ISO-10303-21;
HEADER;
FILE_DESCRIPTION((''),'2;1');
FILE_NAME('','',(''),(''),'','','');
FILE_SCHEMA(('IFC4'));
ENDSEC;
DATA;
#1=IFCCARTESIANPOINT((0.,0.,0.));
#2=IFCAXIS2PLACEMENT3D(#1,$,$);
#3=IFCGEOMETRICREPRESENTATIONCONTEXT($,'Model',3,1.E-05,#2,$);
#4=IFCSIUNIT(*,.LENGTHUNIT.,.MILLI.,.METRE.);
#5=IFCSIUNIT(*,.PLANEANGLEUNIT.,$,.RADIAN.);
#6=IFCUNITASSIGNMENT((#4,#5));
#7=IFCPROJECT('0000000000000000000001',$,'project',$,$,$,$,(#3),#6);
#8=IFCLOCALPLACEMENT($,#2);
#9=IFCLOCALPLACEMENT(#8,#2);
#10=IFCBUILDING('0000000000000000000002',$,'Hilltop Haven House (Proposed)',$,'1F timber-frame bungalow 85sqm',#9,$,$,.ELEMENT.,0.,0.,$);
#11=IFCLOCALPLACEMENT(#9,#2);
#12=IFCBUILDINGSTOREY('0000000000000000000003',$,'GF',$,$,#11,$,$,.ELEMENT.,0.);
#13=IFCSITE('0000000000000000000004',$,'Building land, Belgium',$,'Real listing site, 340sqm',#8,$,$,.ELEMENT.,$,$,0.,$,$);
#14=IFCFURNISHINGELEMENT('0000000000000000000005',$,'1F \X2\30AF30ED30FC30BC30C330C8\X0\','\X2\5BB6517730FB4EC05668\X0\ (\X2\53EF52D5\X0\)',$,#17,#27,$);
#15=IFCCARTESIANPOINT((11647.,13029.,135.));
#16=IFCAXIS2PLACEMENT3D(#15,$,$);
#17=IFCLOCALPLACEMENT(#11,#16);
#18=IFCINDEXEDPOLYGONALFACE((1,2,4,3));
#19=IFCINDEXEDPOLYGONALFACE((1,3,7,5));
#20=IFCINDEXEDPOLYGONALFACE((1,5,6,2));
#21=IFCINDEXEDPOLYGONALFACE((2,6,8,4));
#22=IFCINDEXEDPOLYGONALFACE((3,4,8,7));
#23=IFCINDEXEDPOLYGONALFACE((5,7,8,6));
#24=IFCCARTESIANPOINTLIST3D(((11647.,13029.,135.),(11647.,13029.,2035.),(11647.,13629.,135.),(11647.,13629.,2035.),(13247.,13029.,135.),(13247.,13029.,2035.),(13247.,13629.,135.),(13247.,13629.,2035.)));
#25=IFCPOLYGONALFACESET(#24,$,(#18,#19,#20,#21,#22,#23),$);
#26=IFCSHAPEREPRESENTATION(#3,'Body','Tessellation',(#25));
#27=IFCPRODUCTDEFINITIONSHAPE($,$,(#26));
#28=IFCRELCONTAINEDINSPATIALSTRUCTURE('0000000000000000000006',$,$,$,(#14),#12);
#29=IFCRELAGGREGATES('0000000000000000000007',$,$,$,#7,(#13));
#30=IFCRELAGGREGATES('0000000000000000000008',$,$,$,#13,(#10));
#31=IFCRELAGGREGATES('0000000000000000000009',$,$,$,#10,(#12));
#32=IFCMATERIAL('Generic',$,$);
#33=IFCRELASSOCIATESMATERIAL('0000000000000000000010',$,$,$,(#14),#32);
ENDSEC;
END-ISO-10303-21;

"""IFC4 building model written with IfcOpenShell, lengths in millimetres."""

from ifc_helpers import new_model, si_unit, frame, frame_2d, origin, place, context, project, spatial, rectangle, extrude, material, element, save


model = new_model("IFC4")

# Units and contexts
model_context = context("Model", 3, precision=1e-05, world=origin())
ifc_project = project(units=[si_unit("LENGTHUNIT", "METRE", prefix="MILLI"), si_unit("PLANEANGLEUNIT", "RADIAN")], contexts=[model_context])

# Site, building, storey
site_placement = place(None, origin())
site = spatial("IfcSite", under=ifc_project, at=site_placement, Name="Building land, Belgium", ObjectType="Real listing site, 340sqm", CompositionType="ELEMENT", RefElevation=0.0)
building_placement = place(site_placement, origin())
building = spatial("IfcBuilding", under=site, at=building_placement, Name="Hilltop Haven House (Proposed)", ObjectType="1F timber-frame bungalow 85sqm", CompositionType="ELEMENT", ElevationOfRefHeight=0.0, ElevationOfTerrain=0.0)
storey_placement = place(building_placement, origin())
storey = spatial("IfcBuildingStorey", under=building, at=storey_placement, Name="GF", CompositionType="ELEMENT", Elevation=0.0)

# Shared definitions
ifc_material_1 = material(Name="Generic")

# Furnishing element
furnishing_placement = place(storey_placement, frame((11647.0, 13029.0, 135.0)))
element("IfcFurnishingElement", 1, at=furnishing_placement, inside=storey, material=ifc_material_1, Name="1F クローゼット", Description="家具・什器 (可動)", context=model_context, shape_type="SweptSolid", body=[
    extrude(rectangle(XDim=1600.0, YDim=600.0, at=frame_2d((800.0, 300.0))), frame((11647.0, 13029.0, 135.0)), (0.0, 0.0, 1.0), 1900.0),
])

save(model, "model.ifc")
